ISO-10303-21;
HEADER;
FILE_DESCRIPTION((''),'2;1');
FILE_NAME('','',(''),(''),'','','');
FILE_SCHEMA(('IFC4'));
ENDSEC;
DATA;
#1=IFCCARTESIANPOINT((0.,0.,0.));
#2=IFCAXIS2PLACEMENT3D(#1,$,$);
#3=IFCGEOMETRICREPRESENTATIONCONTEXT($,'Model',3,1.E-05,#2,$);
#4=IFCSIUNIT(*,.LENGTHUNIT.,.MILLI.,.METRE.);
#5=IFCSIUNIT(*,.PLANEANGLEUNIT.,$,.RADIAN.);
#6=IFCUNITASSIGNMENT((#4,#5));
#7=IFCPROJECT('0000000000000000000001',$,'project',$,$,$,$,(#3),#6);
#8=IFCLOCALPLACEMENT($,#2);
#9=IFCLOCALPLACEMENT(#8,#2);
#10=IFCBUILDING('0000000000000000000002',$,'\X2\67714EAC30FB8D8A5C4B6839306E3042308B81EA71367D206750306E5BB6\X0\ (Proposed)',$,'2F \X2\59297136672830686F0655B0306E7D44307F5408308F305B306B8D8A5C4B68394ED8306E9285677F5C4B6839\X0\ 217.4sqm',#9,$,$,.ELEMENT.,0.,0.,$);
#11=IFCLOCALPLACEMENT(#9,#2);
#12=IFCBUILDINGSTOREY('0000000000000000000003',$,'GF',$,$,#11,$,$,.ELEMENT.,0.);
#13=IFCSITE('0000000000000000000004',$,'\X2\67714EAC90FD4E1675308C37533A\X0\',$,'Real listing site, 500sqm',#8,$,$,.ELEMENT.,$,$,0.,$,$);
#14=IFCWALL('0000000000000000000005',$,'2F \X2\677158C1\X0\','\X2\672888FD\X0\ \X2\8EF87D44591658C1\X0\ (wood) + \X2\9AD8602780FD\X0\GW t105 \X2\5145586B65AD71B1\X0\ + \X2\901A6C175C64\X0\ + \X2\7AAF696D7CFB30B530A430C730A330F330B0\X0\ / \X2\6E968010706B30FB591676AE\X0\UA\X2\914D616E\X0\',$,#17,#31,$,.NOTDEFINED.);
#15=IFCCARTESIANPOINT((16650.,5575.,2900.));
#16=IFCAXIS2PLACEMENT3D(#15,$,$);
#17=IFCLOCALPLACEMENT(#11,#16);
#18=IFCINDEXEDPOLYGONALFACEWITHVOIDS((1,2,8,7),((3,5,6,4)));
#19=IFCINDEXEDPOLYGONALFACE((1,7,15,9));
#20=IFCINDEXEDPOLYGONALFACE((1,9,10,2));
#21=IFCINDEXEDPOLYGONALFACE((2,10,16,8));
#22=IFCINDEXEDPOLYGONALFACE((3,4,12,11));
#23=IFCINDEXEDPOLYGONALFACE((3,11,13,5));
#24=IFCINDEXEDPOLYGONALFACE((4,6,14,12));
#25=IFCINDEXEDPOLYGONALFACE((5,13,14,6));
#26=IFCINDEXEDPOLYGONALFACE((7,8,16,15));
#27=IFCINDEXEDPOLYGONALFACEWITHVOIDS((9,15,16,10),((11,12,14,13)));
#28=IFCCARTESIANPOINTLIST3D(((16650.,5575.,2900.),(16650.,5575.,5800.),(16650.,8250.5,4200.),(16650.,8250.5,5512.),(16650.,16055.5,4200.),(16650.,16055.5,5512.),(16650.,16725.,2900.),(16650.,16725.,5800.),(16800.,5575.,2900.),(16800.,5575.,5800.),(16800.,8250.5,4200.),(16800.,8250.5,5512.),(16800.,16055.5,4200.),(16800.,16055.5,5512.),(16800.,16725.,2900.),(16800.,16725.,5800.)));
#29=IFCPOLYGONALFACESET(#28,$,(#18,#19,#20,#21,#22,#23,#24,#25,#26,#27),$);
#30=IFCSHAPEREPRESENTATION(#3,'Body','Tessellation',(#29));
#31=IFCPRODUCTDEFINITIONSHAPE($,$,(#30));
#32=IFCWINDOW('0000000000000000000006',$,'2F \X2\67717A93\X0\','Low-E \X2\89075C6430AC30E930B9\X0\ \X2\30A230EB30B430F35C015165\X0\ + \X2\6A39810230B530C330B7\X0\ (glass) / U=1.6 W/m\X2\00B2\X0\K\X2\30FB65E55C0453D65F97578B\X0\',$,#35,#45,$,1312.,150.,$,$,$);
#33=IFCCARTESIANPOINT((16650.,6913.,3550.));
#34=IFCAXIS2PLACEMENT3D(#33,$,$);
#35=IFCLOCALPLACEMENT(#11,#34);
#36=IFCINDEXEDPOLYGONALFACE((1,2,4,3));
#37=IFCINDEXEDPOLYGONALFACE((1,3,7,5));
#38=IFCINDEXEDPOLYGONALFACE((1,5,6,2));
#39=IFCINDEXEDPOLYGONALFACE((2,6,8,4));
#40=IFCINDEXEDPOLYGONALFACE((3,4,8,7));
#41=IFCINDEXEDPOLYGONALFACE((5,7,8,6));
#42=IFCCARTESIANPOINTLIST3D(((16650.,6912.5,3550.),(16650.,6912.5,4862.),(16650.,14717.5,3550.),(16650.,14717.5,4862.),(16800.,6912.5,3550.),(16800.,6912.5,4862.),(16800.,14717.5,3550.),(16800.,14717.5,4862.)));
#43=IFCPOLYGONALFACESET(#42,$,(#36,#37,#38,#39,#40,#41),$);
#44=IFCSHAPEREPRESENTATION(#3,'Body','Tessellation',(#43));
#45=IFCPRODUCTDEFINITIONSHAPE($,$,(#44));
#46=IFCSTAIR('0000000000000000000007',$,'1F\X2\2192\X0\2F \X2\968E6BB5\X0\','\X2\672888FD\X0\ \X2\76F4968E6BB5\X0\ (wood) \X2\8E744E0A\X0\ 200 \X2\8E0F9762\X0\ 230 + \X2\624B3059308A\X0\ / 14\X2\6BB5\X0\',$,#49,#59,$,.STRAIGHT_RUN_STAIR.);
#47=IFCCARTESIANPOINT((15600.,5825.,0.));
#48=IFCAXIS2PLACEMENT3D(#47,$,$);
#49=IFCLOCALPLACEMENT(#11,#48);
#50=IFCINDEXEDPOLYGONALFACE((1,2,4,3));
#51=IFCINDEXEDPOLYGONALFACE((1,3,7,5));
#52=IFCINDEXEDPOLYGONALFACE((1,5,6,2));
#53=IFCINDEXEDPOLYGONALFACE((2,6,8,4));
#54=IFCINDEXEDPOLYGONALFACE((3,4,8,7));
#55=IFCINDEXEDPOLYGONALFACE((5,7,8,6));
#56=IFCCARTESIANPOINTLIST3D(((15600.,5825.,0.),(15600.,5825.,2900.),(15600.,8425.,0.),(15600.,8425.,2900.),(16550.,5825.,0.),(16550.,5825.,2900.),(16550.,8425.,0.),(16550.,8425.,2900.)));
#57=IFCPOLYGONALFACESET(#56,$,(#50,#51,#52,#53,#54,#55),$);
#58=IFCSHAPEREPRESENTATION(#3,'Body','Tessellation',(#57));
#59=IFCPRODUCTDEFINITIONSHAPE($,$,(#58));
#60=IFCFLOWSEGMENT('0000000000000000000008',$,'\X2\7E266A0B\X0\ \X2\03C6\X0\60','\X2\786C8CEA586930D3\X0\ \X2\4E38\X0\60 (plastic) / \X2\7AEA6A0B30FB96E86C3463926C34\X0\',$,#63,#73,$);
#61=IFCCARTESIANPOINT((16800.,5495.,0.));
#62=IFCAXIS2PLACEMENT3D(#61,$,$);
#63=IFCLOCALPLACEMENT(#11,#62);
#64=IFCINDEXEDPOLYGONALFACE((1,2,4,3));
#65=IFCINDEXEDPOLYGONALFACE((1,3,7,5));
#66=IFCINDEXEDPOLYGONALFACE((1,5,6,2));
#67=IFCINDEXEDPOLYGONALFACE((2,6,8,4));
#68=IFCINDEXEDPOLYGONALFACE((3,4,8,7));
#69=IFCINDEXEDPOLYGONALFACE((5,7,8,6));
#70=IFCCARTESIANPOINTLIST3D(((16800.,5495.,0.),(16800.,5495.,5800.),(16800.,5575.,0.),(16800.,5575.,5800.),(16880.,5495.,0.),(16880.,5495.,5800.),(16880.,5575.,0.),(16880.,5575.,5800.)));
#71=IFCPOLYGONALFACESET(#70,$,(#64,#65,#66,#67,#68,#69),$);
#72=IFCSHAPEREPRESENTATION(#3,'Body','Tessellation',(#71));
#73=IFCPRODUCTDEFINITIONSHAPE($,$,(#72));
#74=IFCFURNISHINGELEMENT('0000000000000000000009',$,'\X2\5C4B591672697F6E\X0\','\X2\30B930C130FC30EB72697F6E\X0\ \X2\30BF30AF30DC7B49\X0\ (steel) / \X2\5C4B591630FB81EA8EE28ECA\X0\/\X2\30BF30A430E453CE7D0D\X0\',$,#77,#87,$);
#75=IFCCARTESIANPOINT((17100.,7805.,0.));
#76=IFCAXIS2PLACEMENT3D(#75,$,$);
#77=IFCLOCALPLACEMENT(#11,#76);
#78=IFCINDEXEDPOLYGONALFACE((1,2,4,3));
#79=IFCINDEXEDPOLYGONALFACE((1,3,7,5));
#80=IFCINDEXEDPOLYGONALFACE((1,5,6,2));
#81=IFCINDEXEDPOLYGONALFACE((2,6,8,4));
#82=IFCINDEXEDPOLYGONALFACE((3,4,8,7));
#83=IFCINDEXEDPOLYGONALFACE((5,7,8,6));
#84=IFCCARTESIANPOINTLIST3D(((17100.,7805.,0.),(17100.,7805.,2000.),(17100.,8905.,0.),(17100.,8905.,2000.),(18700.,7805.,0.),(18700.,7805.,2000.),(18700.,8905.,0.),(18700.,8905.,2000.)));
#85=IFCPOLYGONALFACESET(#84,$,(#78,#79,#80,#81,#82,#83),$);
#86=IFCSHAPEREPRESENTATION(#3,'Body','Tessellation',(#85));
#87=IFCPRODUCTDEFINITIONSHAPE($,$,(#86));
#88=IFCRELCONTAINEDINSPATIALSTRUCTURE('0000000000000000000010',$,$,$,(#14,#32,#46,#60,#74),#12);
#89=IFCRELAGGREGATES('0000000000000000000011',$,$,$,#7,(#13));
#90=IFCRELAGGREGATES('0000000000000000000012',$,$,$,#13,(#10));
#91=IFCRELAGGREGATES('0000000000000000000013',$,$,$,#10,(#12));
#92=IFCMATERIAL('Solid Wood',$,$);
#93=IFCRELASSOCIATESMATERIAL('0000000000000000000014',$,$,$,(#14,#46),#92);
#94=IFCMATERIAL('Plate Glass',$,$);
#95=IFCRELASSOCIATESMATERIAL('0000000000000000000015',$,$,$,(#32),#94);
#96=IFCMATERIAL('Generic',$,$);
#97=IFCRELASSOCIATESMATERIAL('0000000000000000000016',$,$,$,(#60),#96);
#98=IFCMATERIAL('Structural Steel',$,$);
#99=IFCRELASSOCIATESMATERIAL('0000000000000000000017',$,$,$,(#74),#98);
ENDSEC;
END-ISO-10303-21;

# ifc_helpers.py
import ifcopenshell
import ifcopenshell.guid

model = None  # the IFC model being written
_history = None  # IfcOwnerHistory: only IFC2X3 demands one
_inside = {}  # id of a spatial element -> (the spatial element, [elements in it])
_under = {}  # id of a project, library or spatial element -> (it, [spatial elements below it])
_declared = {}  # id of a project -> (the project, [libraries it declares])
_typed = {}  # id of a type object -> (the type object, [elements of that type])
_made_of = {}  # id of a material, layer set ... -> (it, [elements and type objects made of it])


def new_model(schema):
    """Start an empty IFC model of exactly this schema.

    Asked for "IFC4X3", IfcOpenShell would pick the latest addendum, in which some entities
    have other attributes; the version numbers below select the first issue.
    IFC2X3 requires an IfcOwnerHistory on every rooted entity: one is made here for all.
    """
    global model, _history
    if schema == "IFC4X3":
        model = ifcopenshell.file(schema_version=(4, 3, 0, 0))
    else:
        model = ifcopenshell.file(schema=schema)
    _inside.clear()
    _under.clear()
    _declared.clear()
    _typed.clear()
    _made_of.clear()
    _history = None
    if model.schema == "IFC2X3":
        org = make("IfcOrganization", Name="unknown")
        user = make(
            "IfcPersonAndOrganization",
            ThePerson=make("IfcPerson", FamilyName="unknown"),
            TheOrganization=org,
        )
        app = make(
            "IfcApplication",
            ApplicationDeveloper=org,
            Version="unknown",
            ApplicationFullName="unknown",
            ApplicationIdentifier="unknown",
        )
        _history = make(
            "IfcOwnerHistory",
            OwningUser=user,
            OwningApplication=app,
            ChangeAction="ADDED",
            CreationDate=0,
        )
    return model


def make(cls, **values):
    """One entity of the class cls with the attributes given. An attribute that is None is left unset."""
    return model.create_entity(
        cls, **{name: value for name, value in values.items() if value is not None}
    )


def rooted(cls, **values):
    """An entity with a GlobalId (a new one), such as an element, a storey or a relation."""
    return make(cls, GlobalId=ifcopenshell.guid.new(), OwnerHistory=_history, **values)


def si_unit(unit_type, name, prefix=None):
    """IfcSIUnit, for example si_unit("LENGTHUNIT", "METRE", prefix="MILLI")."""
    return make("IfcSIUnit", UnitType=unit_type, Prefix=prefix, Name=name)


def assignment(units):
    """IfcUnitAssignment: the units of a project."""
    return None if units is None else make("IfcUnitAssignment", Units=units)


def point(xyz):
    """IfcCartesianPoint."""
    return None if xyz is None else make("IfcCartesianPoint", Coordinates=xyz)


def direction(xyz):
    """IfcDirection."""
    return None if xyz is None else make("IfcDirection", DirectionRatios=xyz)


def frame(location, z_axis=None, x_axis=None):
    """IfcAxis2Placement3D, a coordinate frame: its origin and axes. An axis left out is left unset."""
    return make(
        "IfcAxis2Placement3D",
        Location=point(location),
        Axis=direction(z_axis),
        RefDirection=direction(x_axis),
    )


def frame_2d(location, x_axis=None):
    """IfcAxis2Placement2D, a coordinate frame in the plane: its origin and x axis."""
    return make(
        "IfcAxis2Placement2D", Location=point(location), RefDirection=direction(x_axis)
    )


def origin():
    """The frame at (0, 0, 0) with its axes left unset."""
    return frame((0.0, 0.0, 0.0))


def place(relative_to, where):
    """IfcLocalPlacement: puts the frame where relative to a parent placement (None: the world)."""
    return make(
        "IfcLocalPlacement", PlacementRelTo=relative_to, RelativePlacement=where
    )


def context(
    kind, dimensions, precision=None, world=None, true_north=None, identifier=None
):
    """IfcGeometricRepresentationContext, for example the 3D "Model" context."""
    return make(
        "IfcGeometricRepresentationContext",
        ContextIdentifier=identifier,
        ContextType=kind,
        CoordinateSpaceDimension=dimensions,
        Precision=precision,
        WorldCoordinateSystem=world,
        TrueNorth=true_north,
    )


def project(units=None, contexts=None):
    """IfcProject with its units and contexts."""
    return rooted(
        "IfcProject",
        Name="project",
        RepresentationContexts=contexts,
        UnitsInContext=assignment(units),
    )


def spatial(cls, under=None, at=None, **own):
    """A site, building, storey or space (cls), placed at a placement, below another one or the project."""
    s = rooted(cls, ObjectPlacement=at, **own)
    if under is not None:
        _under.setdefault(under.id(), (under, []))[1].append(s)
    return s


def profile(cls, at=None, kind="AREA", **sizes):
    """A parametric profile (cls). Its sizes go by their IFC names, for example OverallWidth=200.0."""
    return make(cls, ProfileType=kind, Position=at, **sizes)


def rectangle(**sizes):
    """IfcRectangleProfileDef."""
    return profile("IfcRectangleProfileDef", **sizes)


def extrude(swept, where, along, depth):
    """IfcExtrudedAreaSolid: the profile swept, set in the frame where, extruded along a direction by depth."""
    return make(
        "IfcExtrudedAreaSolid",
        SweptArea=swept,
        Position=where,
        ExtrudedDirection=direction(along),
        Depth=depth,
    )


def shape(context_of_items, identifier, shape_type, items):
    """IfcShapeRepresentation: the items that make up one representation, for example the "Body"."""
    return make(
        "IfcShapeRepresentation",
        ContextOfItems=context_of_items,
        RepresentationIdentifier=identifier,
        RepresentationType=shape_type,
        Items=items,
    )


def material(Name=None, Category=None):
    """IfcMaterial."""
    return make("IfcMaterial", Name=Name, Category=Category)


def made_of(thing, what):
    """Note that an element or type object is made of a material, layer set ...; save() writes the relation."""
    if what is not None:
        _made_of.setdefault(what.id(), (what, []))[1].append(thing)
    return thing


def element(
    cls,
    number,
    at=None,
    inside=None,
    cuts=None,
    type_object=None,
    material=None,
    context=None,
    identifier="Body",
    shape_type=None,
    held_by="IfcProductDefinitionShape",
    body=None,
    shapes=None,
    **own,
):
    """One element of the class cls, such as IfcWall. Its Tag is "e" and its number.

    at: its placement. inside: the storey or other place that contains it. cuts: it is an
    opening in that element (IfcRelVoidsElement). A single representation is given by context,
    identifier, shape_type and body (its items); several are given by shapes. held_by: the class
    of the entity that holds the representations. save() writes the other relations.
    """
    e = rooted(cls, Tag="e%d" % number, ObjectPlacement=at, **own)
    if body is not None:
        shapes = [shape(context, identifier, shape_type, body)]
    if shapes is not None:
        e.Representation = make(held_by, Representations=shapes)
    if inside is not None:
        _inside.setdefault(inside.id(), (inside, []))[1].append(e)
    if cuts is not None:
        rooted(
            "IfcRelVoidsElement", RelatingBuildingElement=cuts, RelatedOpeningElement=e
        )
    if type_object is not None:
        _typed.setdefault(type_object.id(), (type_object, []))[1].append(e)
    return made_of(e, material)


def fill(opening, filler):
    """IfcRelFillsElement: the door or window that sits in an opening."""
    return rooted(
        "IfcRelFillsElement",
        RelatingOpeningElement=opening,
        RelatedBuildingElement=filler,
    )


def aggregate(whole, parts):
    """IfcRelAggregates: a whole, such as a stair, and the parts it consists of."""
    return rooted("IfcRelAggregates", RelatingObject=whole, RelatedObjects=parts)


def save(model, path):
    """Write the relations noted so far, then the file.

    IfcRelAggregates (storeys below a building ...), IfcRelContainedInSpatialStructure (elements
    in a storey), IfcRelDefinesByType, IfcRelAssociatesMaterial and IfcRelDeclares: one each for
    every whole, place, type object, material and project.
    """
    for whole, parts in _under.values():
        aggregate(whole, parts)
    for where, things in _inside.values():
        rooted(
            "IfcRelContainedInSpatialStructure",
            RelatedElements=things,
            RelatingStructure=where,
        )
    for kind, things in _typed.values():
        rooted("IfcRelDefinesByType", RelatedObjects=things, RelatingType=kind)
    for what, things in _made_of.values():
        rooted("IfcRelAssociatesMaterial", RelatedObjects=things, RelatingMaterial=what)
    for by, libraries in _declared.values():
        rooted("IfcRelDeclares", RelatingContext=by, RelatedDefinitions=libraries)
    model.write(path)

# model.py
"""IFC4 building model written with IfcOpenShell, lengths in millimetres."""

from ifc_helpers import new_model, si_unit, frame, frame_2d, origin, place, context, project, spatial, rectangle, extrude, material, element, fill, save


model = new_model("IFC4")

# Units and contexts
model_context = context("Model", 3, precision=1e-05, world=origin())
ifc_project = project(units=[si_unit("LENGTHUNIT", "METRE", prefix="MILLI"), si_unit("PLANEANGLEUNIT", "RADIAN")], contexts=[model_context])

# Site, building, storey
site_placement = place(None, origin())
site = spatial("IfcSite", under=ifc_project, at=site_placement, Name="東京都世田谷区", ObjectType="Real listing site, 500sqm", CompositionType="ELEMENT", RefElevation=0.0)
building_placement = place(site_placement, origin())
building = spatial("IfcBuilding", under=site, at=building_placement, Name="東京・越屋根のある自然素材の家 (Proposed)", ObjectType="2F 天然木と漆喰の組み合わせに越屋根付の銅板屋根 217.4sqm", CompositionType="ELEMENT", ElevationOfRefHeight=0.0, ElevationOfTerrain=0.0)
storey_placement = place(building_placement, origin())
storey = spatial("IfcBuildingStorey", under=building, at=storey_placement, Name="GF", CompositionType="ELEMENT", Elevation=0.0)

# Shared definitions
ifc_material_1 = material(Name="Solid Wood")

# Wall, opening, window
ifc_material_2 = material(Name="Plate Glass")
wall_1_placement = place(storey_placement, frame((16650.0, 5575.0, 2900.0)))
wall_1 = element("IfcWall", 1, at=wall_1_placement, inside=storey, material=ifc_material_1, Name="2F 東壁", Description="木製 軸組外壁 (wood) + 高性能GW t105 充填断熱 + 通気層 + 窯業系サイディング / 準耐火・外皮UA配慮", PredefinedType="NOTDEFINED", context=model_context, shape_type="SweptSolid", body=[
    extrude(rectangle(XDim=150.0, YDim=11150.0, at=frame_2d((75.0, 5575.0))), frame((16650.0, 5575.0, 2900.0)), (0.0, 0.0, 1.0), 2900.0),
])
opening_1_placement = place(storey_placement, frame((16650.0, 6913.0, 3550.0)))
opening_1 = element("IfcOpeningElement", 2, at=opening_1_placement, cuts=wall_1, PredefinedType="NOTDEFINED", context=model_context, shape_type="SweptSolid", body=[
    extrude(rectangle(XDim=150.0, YDim=7805.0, at=frame_2d((75.0, 3902.0))), frame((16650.0, 6913.0, 3550.0)), (0.0, 0.0, 1.0), 1312.0),
])
window_1_placement = place(storey_placement, frame((16650.0, 6913.0, 3550.0)))
window_1 = element("IfcWindow", 3, at=window_1_placement, inside=storey, material=ifc_material_2, Name="2F 東窓", Description="Low-E 複層ガラス アルゴン封入 + 樹脂サッシ (glass) / U=1.6 W/m²K・日射取得型", OverallHeight=1312.0, OverallWidth=150.0, context=model_context, shape_type="SweptSolid", body=[
    extrude(rectangle(XDim=150.0, YDim=7805.0, at=frame_2d((75.0, 3902.0))), frame((16650.0, 6913.0, 3550.0)), (0.0, 0.0, 1.0), 1312.0),
])
fill(opening_1, window_1)

# Stair
stair_placement = place(storey_placement, frame((15600.0, 5825.0, 0.0)))
element("IfcStair", 4, at=stair_placement, inside=storey, material=ifc_material_1, Name="1F→2F 階段", Description="木製 直階段 (wood) 蹴上 200 踏面 230 + 手すり / 14段", PredefinedType="STRAIGHT_RUN_STAIR", context=model_context, shape_type="SweptSolid", body=[
    extrude(rectangle(XDim=950.0, YDim=2600.0, at=frame_2d((475.0, 1300.0))), frame((15600.0, 5825.0, 0.0)), (0.0, 0.0, 1.0), 2900.0),
])

# Flow segment
ifc_material_3 = material(Name="Generic")
flow_segment_placement = place(storey_placement, frame((16800.0, 5495.0, 0.0)))
element("IfcFlowSegment", 5, at=flow_segment_placement, inside=storey, material=ifc_material_3, Name="縦樋 φ60", Description="硬質塩ビ 丸60 (plastic) / 竪樋・雨水排水", context=model_context, shape_type="SweptSolid", body=[
    extrude(rectangle(XDim=80.0, YDim=80.0, at=frame_2d((40.0, 40.0))), frame((16800.0, 5495.0, 0.0)), (0.0, 0.0, 1.0), 5800.0),
])

# Furnishing element
ifc_material_4 = material(Name="Structural Steel")
furnishing_placement = place(storey_placement, frame((17100.0, 7805.0, 0.0)))
element("IfcFurnishingElement", 6, at=furnishing_placement, inside=storey, material=ifc_material_4, Name="屋外物置", Description="スチール物置 タクボ等 (steel) / 屋外・自転車/タイヤ収納", context=model_context, shape_type="SweptSolid", body=[
    extrude(rectangle(XDim=1600.0, YDim=1100.0, at=frame_2d((800.0, 550.0))), frame((17100.0, 7805.0, 0.0)), (0.0, 0.0, 1.0), 2000.0),
])

save(model, "model.ifc")
